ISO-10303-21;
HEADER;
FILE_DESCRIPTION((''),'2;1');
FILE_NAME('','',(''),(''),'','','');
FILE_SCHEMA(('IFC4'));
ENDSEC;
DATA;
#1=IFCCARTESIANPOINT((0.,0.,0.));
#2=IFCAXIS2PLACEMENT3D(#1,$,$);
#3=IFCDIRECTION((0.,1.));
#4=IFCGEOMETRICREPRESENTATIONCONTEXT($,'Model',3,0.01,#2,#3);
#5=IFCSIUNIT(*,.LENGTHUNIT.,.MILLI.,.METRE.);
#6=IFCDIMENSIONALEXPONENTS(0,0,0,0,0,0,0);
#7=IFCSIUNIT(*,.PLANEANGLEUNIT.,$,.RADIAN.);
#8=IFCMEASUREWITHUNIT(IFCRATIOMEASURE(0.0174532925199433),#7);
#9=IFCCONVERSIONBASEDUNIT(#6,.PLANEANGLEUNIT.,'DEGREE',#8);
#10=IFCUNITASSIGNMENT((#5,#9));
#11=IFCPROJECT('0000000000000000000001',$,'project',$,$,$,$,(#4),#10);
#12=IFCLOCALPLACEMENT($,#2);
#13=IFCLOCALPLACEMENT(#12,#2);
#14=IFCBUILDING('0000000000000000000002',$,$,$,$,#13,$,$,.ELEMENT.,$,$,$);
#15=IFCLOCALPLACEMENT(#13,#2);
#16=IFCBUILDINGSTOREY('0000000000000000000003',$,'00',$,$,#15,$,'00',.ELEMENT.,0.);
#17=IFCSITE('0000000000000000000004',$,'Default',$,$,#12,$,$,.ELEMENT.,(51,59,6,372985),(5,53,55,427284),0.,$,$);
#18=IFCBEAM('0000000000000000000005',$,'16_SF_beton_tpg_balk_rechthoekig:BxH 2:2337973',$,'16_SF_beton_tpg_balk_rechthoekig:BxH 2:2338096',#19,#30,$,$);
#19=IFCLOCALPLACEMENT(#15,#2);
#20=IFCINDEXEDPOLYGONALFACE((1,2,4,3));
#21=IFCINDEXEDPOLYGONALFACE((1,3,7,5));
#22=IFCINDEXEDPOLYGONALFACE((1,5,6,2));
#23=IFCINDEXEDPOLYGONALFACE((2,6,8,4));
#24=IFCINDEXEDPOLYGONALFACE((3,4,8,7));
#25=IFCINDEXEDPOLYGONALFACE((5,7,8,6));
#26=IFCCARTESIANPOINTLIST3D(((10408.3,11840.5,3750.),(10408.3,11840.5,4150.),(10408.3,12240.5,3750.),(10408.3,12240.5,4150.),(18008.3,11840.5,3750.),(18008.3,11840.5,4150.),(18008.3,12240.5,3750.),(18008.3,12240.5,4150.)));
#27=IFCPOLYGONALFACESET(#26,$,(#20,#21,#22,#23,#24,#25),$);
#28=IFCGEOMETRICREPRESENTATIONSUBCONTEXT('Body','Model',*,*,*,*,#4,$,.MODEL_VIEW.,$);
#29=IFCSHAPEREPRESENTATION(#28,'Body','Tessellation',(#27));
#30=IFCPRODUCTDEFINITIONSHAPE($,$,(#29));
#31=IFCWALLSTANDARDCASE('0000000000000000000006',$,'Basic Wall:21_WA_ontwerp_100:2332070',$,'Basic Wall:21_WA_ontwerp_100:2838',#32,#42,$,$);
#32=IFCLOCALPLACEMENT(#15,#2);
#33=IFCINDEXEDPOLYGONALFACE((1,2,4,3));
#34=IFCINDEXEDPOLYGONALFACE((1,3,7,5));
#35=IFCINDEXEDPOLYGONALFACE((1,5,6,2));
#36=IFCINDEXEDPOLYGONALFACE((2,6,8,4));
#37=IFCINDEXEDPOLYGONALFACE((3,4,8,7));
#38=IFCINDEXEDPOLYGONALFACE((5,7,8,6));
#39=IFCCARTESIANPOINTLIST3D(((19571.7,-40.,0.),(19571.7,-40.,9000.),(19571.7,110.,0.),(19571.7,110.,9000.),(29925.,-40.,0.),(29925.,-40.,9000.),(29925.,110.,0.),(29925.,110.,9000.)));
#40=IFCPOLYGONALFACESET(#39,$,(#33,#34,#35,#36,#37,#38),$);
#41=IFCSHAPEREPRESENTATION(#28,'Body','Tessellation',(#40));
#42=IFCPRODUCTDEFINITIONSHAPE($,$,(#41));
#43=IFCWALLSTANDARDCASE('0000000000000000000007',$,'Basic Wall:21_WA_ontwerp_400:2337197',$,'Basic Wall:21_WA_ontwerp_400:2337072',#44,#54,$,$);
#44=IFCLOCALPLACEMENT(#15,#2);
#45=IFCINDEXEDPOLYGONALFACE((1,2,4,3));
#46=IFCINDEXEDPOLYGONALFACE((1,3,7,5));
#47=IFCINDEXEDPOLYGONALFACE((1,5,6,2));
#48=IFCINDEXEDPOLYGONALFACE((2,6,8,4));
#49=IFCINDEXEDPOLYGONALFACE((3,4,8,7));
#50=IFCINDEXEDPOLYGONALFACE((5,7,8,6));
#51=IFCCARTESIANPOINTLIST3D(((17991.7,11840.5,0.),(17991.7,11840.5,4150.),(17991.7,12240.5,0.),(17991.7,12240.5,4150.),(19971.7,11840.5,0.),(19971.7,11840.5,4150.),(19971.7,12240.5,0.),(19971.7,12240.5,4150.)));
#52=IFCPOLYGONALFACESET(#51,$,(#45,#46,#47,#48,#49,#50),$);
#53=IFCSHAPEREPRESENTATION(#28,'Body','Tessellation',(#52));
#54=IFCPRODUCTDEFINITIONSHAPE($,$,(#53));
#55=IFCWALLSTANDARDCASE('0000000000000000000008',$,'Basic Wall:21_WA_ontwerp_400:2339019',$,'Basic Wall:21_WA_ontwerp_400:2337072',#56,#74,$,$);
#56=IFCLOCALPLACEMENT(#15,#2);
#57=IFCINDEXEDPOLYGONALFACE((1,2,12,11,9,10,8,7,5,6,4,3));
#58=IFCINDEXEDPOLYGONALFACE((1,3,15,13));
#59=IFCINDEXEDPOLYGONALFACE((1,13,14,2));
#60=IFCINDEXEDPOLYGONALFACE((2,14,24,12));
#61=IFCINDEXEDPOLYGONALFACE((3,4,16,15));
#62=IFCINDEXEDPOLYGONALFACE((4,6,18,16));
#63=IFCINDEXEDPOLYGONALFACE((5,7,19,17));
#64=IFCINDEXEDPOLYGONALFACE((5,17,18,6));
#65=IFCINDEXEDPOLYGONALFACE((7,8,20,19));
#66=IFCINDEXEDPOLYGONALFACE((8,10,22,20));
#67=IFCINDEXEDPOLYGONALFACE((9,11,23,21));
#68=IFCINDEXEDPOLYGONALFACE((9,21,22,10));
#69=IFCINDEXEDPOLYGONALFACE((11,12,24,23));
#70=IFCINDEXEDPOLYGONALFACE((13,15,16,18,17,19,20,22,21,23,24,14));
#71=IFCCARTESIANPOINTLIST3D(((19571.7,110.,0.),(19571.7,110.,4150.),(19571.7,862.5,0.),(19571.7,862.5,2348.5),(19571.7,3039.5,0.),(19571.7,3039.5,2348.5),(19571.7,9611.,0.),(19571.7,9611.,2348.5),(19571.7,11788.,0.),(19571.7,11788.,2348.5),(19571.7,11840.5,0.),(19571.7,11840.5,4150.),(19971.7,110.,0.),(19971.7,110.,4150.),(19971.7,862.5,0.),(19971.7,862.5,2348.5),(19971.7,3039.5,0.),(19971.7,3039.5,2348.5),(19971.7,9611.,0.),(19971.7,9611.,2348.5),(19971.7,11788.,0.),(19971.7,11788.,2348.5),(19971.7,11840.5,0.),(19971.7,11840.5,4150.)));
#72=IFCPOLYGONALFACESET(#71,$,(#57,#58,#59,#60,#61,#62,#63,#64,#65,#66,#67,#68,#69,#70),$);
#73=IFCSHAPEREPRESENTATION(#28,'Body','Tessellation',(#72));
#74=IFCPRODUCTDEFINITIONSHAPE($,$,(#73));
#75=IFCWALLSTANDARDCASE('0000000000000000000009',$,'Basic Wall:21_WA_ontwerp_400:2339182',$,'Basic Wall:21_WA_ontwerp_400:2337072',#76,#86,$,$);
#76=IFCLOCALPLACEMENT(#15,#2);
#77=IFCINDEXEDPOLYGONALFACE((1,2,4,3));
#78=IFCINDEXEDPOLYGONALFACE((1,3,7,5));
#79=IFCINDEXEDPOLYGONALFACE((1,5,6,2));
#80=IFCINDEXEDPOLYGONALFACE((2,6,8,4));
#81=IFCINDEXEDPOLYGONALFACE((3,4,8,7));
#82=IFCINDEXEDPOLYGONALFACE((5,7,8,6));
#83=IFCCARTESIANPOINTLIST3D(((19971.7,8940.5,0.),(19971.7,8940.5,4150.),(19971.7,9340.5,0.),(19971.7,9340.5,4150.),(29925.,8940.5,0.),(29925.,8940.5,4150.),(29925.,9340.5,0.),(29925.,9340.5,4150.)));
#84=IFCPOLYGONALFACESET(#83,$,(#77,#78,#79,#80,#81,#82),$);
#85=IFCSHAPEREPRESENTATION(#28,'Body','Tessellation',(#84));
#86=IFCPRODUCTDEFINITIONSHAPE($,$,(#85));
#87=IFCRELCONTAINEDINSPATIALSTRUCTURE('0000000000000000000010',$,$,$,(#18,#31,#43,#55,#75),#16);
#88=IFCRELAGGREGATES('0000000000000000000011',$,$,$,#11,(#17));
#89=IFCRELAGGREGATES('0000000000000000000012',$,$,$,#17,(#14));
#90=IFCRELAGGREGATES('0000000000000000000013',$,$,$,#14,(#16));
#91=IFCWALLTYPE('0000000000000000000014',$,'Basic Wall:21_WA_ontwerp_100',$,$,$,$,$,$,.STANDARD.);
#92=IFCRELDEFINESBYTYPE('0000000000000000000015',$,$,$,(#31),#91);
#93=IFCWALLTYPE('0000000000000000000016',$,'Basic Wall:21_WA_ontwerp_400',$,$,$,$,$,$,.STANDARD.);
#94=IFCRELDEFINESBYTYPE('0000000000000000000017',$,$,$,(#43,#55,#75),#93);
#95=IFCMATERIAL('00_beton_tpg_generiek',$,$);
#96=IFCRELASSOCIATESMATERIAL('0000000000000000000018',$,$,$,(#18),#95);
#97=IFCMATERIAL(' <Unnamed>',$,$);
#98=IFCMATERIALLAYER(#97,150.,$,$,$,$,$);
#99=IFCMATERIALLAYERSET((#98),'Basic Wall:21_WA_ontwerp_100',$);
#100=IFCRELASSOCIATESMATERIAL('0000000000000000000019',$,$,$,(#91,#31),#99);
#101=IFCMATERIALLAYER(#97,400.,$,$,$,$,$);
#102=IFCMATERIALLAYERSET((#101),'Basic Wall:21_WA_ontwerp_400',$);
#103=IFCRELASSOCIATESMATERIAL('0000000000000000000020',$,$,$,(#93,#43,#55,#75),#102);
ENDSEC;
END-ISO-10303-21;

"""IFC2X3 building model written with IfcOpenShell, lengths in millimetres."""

from ifc_helpers import new_model, entity, si_unit, converted_unit, direction, frame, frame_2d, origin, origin_2d_with_axis, place, context, subcontext, project, spatial, rectangle, extrude, material, layer, layer_set, layer_usage, type_object, element, save


model = new_model("IFC2X3")

# Units and contexts
model_context = context("Model", 3, precision=0.01, world=origin(), true_north=direction((0.0, 1.0)))
body_context = subcontext(model_context, "Body", "Model", "MODEL_VIEW")
ifc_project = project(units=[si_unit("LENGTHUNIT", "METRE", prefix="MILLI"), converted_unit("PLANEANGLEUNIT", "DEGREE", entity("IfcRatioMeasure", 0.0174532925199433), si_unit("PLANEANGLEUNIT", "RADIAN"), dimensions=[0, 0, 0, 0, 0, 0, 0])], contexts=[model_context])

# Site, building, storey
site_placement = place(None, origin())
site = spatial("IfcSite", under=ifc_project, at=site_placement, Name="Default", CompositionType="ELEMENT", RefLatitude=(51, 59, 6, 372985), RefLongitude=(5, 53, 55, 427284), RefElevation=0.0)
building_placement = place(site_placement, origin())
building = spatial("IfcBuilding", under=site, at=building_placement, CompositionType="ELEMENT")
storey_placement = place(building_placement, origin())
storey = spatial("IfcBuildingStorey", under=building, at=storey_placement, Name="00", LongName="00", CompositionType="ELEMENT", Elevation=0.0)

# Beam
ifc_material_1 = material(Name="00_beton_tpg_generiek")
beam_placement = place(storey_placement, frame((10408.3, 12040.5, 4150.0)))
element("IfcBeam", 1, at=beam_placement, inside=storey, material=ifc_material_1, Name="16_SF_beton_tpg_balk_rechthoekig:BxH 2:2337973", ObjectType="16_SF_beton_tpg_balk_rechthoekig:BxH 2:2338096", context=body_context, shape_type="SweptSolid", body=[
    extrude(rectangle(XDim=400.0, YDim=400.0, at=frame_2d((0.0, 0.0), x_axis=(1.0, 0.0))), frame((0.0, 0.0, -200.0), z_axis=(1.0, 0.0, 0.0), x_axis=(0.0, 0.0, -1.0)), (0.0, 0.0, 1.0), 7600.0),
])

# Walls
ifc_material_2 = material(Name=" <Unnamed>")
ifc_layer_1 = layer(ifc_material_2, 150.0)
ifc_layer_set_1 = layer_set([ifc_layer_1], Name="Basic Wall:21_WA_ontwerp_100")
ifc_layer_usage_1 = layer_usage(ifc_layer_set_1, "AXIS2", "NEGATIVE", 75.0)
wall_type_1 = type_object("IfcWallType", Name="Basic Wall:21_WA_ontwerp_100", PredefinedType="STANDARD", material=ifc_layer_set_1)
wall_1_placement = place(storey_placement, frame((19571.7, 35.0, 0.0)))
element("IfcWallStandardCase", 2, at=wall_1_placement, inside=storey, type_object=wall_type_1, material=ifc_layer_usage_1, Name="Basic Wall:21_WA_ontwerp_100:2332070", ObjectType="Basic Wall:21_WA_ontwerp_100:2838", context=body_context, shape_type="SweptSolid", body=[
    extrude(rectangle(XDim=10353.3, YDim=150.0, at=frame_2d((5176.7, 0.0), x_axis=(-1.0, 0.0))), origin(), (0.0, 0.0, 1.0), 9000.0),
])
ifc_layer_2 = layer(ifc_material_2, 400.0)
ifc_layer_set_2 = layer_set([ifc_layer_2], Name="Basic Wall:21_WA_ontwerp_400")
ifc_layer_usage_2 = layer_usage(ifc_layer_set_2, "AXIS2", "NEGATIVE", 200.0)
wall_type_2 = type_object("IfcWallType", Name="Basic Wall:21_WA_ontwerp_400", PredefinedType="STANDARD", material=ifc_layer_set_2)
wall_2_placement = place(storey_placement, frame((17991.7, 12040.5, 0.0)))
element("IfcWallStandardCase", 3, at=wall_2_placement, inside=storey, type_object=wall_type_2, material=ifc_layer_usage_2, Name="Basic Wall:21_WA_ontwerp_400:2337197", ObjectType="Basic Wall:21_WA_ontwerp_400:2337072", context=body_context, shape_type="SweptSolid", body=[
    extrude(rectangle(XDim=1980.0, YDim=400.0, at=frame_2d((990.0, 0.0), x_axis=(-1.0, 0.0))), origin(), (0.0, 0.0, 1.0), 4150.0),
])

# Wall, openings
ifc_layer_usage_3 = layer_usage(ifc_layer_set_2, "AXIS2", "NEGATIVE", 200.0)
wall_3_placement = place(storey_placement, frame((19771.7, 11840.5, 0.0), z_axis=(0.0, 0.0, 1.0), x_axis=(0.0, -1.0, 0.0)))
wall_3 = element("IfcWallStandardCase", 4, at=wall_3_placement, inside=storey, type_object=wall_type_2, material=ifc_layer_usage_3, Name="Basic Wall:21_WA_ontwerp_400:2339019", ObjectType="Basic Wall:21_WA_ontwerp_400:2337072", context=body_context, shape_type="SweptSolid", body=[
    extrude(rectangle(XDim=11730.5, YDim=400.0, at=frame_2d((5865.2, 0.0), x_axis=(-1.0, 0.0))), origin(), (0.0, 0.0, 1.0), 4150.0),
])
opening_1_placement = place(wall_3_placement, frame((11840.5, -19771.7, 0.0), z_axis=(0.0, 0.0, 1.0), x_axis=(0.0, 1.0, 0.0)))
element("IfcOpeningElement", 5, at=opening_1_placement, cuts=wall_3, ObjectType="Opening", context=body_context, shape_type="SweptSolid", body=[
    extrude(rectangle(XDim=2398.5, YDim=2177.0, at=frame_2d((0.0, 0.0), x_axis=(1.0, 0.0))), frame((19571.7, 10699.5, 1149.3), z_axis=(1.0, 0.0, 0.0), x_axis=(0.0, 0.0, -1.0)), (0.0, 0.0, 1.0), 400.0),
])
opening_2_placement = place(wall_3_placement, frame((11840.5, -19771.7, 0.0), z_axis=(0.0, 0.0, 1.0), x_axis=(0.0, 1.0, 0.0)))
element("IfcOpeningElement", 6, at=opening_2_placement, cuts=wall_3, ObjectType="Opening", context=body_context, shape_type="SweptSolid", body=[
    extrude(rectangle(XDim=2398.5, YDim=2177.0, at=origin_2d_with_axis()), frame((19571.7, 1951.0, 1149.3), z_axis=(1.0, 0.0, 0.0), x_axis=(0.0, 0.0, -1.0)), (0.0, 0.0, 1.0), 400.0),
])

# Wall
ifc_layer_usage_4 = layer_usage(ifc_layer_set_2, "AXIS2", "NEGATIVE", 200.0)
wall_4_placement = place(storey_placement, frame((19971.7, 9140.5, 0.0)))
element("IfcWallStandardCase", 7, at=wall_4_placement, inside=storey, type_object=wall_type_2, material=ifc_layer_usage_4, Name="Basic Wall:21_WA_ontwerp_400:2339182", ObjectType="Basic Wall:21_WA_ontwerp_400:2337072", context=body_context, shape_type="SweptSolid", body=[
    extrude(rectangle(XDim=9953.3, YDim=400.0, at=frame_2d((4976.7, 0.0), x_axis=(-1.0, 0.0))), origin(), (0.0, 0.0, 1.0), 4150.0),
])

save(model, "model.ifc")
